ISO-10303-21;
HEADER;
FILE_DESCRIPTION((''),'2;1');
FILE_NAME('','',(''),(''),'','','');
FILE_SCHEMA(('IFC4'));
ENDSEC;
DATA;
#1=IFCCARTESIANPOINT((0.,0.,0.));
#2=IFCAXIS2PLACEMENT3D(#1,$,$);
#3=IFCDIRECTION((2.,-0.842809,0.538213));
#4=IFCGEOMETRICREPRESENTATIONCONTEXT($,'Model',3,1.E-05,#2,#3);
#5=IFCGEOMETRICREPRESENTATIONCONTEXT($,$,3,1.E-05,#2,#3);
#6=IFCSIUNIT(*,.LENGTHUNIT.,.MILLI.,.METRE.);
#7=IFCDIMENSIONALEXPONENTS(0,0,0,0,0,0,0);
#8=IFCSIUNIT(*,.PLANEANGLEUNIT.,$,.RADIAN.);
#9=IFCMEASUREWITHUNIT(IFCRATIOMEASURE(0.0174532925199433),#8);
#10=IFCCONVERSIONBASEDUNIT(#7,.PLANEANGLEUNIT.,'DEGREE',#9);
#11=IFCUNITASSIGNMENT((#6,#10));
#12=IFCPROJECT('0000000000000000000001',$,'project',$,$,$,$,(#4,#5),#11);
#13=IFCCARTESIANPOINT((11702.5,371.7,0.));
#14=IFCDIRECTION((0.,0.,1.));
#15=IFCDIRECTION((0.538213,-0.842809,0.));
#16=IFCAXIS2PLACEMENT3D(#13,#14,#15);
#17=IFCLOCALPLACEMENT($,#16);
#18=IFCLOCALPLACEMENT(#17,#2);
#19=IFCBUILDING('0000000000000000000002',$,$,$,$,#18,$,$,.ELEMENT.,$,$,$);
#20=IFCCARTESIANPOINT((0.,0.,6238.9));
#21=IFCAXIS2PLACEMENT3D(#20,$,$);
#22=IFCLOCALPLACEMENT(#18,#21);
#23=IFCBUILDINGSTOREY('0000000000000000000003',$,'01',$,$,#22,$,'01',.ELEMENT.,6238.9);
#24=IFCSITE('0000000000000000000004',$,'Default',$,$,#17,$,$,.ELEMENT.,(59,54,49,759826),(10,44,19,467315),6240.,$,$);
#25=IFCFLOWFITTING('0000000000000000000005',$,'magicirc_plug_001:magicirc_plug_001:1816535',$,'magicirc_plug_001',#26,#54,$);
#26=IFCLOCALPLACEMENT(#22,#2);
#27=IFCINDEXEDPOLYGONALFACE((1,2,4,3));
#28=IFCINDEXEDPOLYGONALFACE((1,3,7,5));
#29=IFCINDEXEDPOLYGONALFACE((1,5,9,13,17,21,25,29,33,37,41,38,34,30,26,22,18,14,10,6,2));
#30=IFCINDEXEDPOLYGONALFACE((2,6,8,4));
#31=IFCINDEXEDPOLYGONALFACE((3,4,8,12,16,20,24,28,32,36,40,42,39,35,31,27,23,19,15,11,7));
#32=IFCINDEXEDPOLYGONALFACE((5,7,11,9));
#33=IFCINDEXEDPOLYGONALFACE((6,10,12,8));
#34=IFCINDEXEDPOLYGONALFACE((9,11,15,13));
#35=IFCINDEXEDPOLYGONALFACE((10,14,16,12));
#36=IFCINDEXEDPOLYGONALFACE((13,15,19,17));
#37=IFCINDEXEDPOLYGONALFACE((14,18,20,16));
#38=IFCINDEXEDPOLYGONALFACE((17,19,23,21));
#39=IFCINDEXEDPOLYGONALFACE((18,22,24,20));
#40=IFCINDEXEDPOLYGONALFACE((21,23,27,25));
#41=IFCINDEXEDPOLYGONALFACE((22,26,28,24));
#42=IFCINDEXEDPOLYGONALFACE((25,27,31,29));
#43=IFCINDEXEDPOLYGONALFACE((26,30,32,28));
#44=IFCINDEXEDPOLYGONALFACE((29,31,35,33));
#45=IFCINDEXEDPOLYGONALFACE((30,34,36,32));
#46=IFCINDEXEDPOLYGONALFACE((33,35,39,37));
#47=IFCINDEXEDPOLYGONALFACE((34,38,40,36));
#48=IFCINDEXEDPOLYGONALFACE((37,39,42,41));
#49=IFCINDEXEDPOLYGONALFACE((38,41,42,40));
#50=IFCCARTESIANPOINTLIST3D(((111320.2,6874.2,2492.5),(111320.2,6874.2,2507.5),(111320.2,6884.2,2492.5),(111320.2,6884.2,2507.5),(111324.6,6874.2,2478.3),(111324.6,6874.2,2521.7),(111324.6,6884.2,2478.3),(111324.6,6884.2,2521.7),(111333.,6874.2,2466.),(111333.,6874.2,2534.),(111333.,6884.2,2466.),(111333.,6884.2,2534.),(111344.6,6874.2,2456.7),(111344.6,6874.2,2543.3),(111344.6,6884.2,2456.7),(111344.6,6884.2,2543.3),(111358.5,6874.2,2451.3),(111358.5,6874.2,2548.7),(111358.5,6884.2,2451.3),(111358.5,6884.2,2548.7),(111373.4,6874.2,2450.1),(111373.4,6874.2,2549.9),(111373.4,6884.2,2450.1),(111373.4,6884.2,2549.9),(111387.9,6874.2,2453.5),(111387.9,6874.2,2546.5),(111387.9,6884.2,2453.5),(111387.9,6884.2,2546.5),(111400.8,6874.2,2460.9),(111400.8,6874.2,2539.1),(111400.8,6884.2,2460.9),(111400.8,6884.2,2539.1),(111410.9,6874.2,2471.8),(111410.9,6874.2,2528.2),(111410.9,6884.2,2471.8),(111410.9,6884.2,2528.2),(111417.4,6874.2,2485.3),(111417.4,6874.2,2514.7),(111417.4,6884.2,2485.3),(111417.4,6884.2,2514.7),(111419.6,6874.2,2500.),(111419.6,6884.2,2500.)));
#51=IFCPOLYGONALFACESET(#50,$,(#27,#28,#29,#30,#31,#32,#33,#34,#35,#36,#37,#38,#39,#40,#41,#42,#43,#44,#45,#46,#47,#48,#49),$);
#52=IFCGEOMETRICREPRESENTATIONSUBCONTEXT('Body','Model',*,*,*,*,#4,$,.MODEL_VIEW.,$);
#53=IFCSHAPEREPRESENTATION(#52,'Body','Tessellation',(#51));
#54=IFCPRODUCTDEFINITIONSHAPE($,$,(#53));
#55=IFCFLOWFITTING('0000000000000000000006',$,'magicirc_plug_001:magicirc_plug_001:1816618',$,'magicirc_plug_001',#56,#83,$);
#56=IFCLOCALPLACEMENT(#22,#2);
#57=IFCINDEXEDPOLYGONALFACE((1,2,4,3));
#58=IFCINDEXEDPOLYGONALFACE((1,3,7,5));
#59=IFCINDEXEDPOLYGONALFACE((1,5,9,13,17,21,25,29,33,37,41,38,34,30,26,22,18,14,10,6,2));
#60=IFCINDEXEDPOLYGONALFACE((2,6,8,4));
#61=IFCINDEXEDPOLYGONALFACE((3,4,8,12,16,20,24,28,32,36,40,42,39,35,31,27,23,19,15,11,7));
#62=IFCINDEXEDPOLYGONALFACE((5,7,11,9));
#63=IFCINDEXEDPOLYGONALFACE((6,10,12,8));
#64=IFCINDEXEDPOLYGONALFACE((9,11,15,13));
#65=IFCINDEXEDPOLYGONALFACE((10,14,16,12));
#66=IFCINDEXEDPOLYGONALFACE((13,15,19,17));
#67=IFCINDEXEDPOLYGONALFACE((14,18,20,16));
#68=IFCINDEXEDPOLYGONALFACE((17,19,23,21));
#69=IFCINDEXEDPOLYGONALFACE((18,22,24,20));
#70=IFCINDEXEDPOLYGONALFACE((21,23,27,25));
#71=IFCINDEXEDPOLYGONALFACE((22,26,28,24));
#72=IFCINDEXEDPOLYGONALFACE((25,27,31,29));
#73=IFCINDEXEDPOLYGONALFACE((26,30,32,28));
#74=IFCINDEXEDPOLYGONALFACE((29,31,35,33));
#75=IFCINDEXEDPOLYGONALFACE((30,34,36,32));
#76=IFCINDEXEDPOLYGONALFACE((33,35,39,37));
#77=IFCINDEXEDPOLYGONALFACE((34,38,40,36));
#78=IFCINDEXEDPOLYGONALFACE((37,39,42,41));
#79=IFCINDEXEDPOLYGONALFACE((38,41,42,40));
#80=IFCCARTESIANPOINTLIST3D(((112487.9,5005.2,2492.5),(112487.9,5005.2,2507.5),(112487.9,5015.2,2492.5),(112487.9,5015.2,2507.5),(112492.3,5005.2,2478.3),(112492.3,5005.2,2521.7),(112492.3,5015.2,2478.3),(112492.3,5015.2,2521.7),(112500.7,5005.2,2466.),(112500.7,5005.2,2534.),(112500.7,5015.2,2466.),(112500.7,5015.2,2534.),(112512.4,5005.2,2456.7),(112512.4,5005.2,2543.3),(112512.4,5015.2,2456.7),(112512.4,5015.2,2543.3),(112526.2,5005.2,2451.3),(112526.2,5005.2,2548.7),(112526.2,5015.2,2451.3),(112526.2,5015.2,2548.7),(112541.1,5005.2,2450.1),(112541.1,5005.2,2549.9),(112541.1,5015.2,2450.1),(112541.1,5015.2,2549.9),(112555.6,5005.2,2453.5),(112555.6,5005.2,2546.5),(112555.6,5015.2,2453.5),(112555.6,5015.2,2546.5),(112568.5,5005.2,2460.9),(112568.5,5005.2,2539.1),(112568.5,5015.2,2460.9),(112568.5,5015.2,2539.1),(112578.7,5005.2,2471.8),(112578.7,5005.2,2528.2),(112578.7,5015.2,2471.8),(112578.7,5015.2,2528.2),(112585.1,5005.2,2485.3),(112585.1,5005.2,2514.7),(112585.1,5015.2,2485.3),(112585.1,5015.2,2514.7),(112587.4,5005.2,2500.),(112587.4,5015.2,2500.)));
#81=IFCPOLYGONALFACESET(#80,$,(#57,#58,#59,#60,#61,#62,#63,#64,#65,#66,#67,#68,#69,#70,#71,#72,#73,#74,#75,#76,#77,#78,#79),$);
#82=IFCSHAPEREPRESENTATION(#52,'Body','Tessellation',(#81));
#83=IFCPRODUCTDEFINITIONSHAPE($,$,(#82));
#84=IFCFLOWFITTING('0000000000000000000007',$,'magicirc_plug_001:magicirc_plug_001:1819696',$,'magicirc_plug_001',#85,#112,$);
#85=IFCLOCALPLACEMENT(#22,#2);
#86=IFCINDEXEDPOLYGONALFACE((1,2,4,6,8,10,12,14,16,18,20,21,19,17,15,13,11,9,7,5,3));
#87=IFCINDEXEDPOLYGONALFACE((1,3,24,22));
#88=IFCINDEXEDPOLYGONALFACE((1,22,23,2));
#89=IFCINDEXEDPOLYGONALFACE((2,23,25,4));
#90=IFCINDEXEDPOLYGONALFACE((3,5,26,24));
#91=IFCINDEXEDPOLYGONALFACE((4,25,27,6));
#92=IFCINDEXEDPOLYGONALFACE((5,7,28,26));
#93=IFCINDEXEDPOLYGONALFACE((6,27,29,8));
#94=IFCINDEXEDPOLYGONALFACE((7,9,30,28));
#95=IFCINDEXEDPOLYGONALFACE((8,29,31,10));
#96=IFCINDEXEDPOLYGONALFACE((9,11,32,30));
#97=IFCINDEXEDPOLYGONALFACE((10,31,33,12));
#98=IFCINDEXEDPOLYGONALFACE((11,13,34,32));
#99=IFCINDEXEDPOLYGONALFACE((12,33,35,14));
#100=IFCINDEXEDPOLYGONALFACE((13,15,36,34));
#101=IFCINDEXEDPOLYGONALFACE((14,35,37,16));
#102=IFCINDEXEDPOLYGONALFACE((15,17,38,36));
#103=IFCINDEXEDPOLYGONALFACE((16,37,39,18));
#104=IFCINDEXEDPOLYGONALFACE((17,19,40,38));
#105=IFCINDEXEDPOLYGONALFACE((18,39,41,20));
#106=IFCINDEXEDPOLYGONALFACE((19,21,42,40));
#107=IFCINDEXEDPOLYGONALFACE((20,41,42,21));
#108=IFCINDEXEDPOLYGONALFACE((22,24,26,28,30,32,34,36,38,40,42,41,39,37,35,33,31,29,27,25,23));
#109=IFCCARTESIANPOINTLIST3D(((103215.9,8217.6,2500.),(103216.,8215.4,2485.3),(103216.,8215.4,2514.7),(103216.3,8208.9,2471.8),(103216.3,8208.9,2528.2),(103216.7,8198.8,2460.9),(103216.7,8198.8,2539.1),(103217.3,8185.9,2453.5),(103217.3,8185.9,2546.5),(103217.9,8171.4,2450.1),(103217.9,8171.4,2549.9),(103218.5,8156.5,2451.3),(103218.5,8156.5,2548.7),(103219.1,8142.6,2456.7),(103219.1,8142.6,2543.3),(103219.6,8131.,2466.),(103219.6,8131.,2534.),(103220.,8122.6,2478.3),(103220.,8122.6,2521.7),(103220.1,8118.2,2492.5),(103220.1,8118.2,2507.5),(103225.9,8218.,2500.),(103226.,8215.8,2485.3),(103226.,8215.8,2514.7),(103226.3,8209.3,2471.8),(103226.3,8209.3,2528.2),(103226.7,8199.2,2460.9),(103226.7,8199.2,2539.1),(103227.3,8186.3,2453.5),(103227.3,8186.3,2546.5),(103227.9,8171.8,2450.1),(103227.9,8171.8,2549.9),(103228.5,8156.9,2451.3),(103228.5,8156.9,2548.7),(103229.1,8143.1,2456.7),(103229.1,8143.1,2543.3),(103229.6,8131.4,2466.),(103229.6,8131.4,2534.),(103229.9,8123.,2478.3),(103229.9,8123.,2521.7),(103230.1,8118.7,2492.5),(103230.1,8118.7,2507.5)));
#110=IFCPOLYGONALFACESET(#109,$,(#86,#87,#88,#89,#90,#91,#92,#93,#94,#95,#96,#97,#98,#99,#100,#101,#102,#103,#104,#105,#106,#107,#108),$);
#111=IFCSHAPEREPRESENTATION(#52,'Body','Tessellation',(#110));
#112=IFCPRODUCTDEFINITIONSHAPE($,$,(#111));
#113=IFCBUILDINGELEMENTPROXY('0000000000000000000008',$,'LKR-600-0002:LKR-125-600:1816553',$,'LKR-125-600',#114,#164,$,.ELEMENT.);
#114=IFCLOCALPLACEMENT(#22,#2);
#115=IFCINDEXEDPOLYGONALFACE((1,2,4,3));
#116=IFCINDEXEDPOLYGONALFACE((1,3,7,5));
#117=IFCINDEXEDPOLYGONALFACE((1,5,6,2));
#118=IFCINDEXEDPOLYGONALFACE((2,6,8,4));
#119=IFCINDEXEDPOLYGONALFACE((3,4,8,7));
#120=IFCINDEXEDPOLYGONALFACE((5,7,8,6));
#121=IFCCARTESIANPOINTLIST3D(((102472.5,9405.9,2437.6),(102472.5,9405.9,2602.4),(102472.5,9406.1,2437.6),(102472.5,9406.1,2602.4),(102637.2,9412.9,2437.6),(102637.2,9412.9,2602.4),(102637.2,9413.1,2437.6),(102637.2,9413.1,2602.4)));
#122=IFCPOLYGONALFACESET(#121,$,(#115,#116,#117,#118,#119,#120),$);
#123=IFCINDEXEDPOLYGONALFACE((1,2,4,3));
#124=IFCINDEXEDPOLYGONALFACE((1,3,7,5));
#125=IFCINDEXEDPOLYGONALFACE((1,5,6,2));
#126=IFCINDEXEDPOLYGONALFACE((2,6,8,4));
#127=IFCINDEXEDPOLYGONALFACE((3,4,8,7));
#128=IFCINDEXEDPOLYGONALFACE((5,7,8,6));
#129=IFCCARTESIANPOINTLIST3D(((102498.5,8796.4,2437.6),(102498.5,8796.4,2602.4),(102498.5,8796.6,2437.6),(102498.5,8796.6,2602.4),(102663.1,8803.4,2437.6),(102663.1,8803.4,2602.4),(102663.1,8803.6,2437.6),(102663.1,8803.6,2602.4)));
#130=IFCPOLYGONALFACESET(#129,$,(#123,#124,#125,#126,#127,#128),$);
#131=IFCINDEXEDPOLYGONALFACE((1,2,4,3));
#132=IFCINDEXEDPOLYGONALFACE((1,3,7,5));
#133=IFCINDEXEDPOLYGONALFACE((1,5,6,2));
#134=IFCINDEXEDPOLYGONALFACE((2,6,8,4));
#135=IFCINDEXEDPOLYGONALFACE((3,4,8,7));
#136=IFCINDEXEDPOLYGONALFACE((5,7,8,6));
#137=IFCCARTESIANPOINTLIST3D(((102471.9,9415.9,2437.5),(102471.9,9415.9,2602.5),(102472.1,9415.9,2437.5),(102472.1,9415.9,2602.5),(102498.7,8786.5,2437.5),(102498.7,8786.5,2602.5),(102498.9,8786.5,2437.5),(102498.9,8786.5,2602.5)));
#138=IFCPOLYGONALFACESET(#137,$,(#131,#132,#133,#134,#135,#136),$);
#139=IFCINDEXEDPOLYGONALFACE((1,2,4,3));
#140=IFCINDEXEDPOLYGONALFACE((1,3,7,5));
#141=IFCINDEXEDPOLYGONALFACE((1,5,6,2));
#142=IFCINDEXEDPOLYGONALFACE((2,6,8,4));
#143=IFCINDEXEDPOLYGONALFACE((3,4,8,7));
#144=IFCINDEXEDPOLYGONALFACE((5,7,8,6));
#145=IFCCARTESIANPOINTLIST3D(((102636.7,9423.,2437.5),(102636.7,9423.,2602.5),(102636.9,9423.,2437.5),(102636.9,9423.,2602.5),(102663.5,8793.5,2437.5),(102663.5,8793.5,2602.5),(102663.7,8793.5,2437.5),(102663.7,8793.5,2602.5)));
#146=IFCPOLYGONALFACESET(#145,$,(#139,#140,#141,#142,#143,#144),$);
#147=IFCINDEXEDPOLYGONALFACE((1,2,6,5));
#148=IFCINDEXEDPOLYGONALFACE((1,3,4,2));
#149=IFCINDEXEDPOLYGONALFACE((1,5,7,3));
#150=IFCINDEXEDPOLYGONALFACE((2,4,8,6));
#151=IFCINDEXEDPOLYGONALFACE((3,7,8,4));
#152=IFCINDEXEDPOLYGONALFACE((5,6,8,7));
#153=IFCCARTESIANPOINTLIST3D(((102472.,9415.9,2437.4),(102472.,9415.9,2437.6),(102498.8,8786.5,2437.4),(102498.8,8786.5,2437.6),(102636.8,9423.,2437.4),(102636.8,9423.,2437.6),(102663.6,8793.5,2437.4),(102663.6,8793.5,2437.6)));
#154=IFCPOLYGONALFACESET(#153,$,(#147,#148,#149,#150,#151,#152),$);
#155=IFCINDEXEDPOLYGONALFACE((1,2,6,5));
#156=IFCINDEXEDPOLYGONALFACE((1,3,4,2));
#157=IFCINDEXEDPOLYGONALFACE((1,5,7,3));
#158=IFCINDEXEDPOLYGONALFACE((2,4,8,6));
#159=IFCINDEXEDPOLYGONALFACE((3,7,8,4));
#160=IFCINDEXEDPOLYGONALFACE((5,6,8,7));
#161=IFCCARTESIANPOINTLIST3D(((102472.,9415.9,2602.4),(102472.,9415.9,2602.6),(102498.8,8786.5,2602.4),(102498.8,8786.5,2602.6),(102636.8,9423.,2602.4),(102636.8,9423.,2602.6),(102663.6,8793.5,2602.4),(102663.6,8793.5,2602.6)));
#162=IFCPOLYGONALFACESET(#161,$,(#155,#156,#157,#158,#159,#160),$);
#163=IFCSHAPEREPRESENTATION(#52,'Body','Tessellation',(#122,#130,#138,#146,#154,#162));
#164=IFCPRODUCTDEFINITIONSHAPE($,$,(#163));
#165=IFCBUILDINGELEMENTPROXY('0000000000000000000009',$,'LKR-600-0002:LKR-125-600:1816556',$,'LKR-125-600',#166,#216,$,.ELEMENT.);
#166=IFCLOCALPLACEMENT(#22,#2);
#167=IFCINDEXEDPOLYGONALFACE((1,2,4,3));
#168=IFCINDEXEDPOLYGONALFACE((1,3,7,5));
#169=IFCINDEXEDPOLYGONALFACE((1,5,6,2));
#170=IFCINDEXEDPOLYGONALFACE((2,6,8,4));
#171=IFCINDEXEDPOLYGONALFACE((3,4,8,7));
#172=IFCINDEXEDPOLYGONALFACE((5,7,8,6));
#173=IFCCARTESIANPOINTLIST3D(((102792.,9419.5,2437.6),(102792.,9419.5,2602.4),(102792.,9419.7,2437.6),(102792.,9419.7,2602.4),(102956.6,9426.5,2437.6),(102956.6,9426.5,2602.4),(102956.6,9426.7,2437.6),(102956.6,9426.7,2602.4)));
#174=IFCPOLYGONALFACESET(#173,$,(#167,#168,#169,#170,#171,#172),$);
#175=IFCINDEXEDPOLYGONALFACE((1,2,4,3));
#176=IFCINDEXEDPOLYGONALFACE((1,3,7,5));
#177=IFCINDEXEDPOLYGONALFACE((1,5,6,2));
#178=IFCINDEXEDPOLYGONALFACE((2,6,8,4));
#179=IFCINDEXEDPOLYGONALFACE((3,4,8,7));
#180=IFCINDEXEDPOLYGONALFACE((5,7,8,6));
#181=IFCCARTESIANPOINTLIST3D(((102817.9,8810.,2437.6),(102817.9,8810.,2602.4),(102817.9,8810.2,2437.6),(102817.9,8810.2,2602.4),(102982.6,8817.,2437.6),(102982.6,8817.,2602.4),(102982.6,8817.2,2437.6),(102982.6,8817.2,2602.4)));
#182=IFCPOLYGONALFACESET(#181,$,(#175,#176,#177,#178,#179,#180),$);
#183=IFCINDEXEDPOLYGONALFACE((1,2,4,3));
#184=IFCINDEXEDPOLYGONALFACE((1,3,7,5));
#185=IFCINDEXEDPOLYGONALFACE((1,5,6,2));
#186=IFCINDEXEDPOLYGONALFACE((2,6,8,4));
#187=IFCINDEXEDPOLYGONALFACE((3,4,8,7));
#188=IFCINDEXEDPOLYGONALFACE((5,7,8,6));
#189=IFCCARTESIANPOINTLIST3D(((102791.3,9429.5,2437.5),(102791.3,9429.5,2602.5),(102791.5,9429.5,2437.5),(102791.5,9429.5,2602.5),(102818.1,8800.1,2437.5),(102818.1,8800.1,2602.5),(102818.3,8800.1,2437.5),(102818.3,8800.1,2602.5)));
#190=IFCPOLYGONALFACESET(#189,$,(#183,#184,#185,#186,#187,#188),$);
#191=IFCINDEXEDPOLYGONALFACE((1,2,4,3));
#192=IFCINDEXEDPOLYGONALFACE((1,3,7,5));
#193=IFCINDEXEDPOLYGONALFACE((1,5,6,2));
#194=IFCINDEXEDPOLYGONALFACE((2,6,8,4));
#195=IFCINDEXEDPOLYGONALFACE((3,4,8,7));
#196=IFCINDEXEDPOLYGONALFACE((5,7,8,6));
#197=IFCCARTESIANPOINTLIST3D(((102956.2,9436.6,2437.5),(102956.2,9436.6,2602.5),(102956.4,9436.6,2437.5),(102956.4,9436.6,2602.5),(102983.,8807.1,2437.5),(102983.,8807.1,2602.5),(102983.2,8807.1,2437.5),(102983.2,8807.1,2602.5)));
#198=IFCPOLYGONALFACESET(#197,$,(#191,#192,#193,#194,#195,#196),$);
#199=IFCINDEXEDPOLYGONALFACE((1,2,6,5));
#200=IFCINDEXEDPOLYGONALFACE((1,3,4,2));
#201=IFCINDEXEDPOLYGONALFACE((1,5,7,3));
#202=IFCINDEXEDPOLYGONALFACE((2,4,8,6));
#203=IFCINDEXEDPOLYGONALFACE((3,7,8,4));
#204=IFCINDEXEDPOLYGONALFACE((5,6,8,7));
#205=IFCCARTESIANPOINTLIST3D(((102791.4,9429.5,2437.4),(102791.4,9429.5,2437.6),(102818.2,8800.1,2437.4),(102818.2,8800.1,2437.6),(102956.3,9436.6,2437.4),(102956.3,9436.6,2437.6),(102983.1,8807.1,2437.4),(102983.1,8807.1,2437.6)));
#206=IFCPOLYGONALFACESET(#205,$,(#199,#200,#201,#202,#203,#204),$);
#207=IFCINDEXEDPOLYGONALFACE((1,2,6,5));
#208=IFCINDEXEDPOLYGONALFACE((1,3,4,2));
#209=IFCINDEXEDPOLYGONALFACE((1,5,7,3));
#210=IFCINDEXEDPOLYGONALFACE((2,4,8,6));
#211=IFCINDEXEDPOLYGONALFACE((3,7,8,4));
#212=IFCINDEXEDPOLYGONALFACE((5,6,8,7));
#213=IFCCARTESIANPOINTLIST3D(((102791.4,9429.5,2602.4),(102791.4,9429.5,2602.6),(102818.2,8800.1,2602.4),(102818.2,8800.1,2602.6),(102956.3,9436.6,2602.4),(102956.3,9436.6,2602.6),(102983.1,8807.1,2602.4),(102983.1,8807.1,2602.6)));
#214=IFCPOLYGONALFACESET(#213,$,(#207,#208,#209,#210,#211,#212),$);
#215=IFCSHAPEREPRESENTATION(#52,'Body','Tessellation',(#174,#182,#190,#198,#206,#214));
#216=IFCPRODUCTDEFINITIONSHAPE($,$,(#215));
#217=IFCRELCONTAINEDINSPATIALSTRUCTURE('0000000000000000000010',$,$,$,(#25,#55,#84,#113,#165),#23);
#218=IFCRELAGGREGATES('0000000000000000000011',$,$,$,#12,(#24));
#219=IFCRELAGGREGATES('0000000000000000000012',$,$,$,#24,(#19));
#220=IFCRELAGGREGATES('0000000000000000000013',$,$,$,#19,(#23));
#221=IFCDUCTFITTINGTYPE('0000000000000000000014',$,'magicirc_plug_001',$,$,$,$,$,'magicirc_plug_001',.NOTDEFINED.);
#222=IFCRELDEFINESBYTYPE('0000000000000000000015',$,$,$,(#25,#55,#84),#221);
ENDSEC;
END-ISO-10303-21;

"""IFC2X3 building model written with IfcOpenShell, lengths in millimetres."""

from ifc_helpers import new_model, entity, si_unit, converted_unit, direction, frame, frame_2d, origin, place, context, subcontext, project, spatial, rectangle, circle, extrude, source, transform, mapped, type_object, type_shapes, element, save


model = new_model("IFC2X3")

# Units and contexts
model_context = context("Model", 3, precision=1e-05, world=origin(), true_north=direction((2.0, -0.842809, 0.538213)))
context_of_model = context(None, 3, precision=1e-05, world=origin(), true_north=direction((2.0, -0.842809, 0.538213)))
body_context = subcontext(model_context, "Body", "Model", "MODEL_VIEW")
ifc_project = project(units=[si_unit("LENGTHUNIT", "METRE", prefix="MILLI"), converted_unit("PLANEANGLEUNIT", "DEGREE", entity("IfcRatioMeasure", 0.0174532925199433), si_unit("PLANEANGLEUNIT", "RADIAN"), dimensions=[0, 0, 0, 0, 0, 0, 0])], contexts=[model_context, context_of_model])

# Site, building, storey
site_placement = place(None, frame((11702.5, 371.7, 0.0), z_axis=(0.0, 0.0, 1.0), x_axis=(0.538213, -0.842809, 0.0)))
site = spatial("IfcSite", under=ifc_project, at=site_placement, Name="Default", CompositionType="ELEMENT", RefLatitude=(59, 54, 49, 759826), RefLongitude=(10, 44, 19, 467315), RefElevation=6240.0)
building_placement = place(site_placement, origin())
building = spatial("IfcBuilding", under=site, at=building_placement, CompositionType="ELEMENT")
storey_placement = place(building_placement, frame((0.0, 0.0, 6238.9)))
storey = spatial("IfcBuildingStorey", under=building, at=storey_placement, Name="01", LongName="01", CompositionType="ELEMENT", Elevation=6238.9)

# Flow fittings
duct_fitting_type_1 = type_object("IfcDuctFittingType", Name="magicirc_plug_001", ElementType="magicirc_plug_001", PredefinedType="NOTDEFINED")
shared_shape_1 = source(origin(), body_context, "Body", "SweptSolid", [
    extrude(circle(Radius=50.0, at=frame_2d((0.0, 0.0), x_axis=(1.0, 0.0))), frame((0.0, 0.0, 0.0), z_axis=(1.0, 0.0, 0.0), x_axis=(0.0, 1.0, 0.0)), (0.0, 0.0, 1.0), 10.0),
])
type_shapes(duct_fitting_type_1, [shared_shape_1])
for number, where, z_axis, x_axis, name in (
    (1, (111369.6, 6884.2, 2500.0), (0.0, 0.0, 1.0), (0.0, -1.0, 0.0), "magicirc_plug_001:magicirc_plug_001:1816535"),
    (2, (112537.4, 5015.2, 2500.0), (0.0, 0.0, 1.0), (0.0, -1.0, 0.0), "magicirc_plug_001:magicirc_plug_001:1816618"),
    (3, (103218.0, 8167.6, 2500.0), (0.0, 0.0, 1.0), (0.999095, 0.042537, 0.0), "magicirc_plug_001:magicirc_plug_001:1819696"),
):
    element("IfcFlowFitting", number, at=place(storey_placement, frame(where, z_axis=z_axis, x_axis=x_axis)), inside=storey, type_object=duct_fitting_type_1, Name=name, ObjectType="magicirc_plug_001", context=body_context, shape_type="MappedRepresentation", body=[
        mapped(shared_shape_1, transform((0.0, 0.0, 0.0), scale=1.0)),
    ])

# Building element proxies
shared_shape_2 = source(origin(), body_context, "Body", "SweptSolid", [
    extrude(rectangle(XDim=0.2, YDim=164.8, at=frame_2d((0.0, 0.0), x_axis=(1.0, 0.0))), frame((305.0, 0.0, -82.4)), (0.0, 0.0, 1.0), 164.8),
    extrude(rectangle(XDim=0.2, YDim=164.8, at=frame_2d((0.0, 0.0), x_axis=(1.0, 0.0))), frame((-305.0, 0.0, -82.4)), (0.0, 0.0, 1.0), 164.8),
    extrude(rectangle(XDim=0.2, YDim=630.0, at=frame_2d((0.0, 0.0), x_axis=(1.0, 0.0))), frame((0.0, 82.5, -82.5), z_axis=(0.0, 0.0, 1.0), x_axis=(0.0, 1.0, 0.0)), (0.0, 0.0, 1.0), 165.0),
    extrude(rectangle(XDim=0.2, YDim=630.0, at=frame_2d((0.0, 0.0), x_axis=(1.0, 0.0))), frame((0.0, -82.5, -82.5), z_axis=(0.0, 0.0, 1.0), x_axis=(0.0, 1.0, 0.0)), (0.0, 0.0, 1.0), 165.0),
    extrude(rectangle(XDim=165.0, YDim=630.0, at=frame_2d((0.0, 0.0), x_axis=(1.0, 0.0))), frame((0.0, 0.0, -82.6), z_axis=(0.0, 0.0, 1.0), x_axis=(0.0, -1.0, 0.0)), (0.0, 0.0, 1.0), 0.2),
    extrude(rectangle(XDim=165.0, YDim=630.0, at=frame_2d((0.0, 0.0), x_axis=(1.0, 0.0))), frame((0.0, 0.0, 82.4), z_axis=(0.0, 0.0, 1.0), x_axis=(0.0, -1.0, 0.0)), (0.0, 0.0, 1.0), 0.2),
])
for number, where, z_axis, x_axis, name in (
    (4, (102567.8, 9104.7, 2520.0), (0.0, 0.0, 1.0), (-0.042537, 0.999095, 0.0), "LKR-600-0002:LKR-125-600:1816553"),
    (5, (102887.3, 9118.3, 2520.0), (0.0, 0.0, 1.0), (-0.042537, 0.999095, 0.0), "LKR-600-0002:LKR-125-600:1816556"),
):
    element("IfcBuildingElementProxy", number, at=place(storey_placement, frame(where, z_axis=z_axis, x_axis=x_axis)), inside=storey, Name=name, ObjectType="LKR-125-600", CompositionType="ELEMENT", context=body_context, shape_type="MappedRepresentation", body=[
        mapped(shared_shape_2, transform((0.0, 0.0, 0.0), scale=1.0)),
    ])

save(model, "model.ifc")
